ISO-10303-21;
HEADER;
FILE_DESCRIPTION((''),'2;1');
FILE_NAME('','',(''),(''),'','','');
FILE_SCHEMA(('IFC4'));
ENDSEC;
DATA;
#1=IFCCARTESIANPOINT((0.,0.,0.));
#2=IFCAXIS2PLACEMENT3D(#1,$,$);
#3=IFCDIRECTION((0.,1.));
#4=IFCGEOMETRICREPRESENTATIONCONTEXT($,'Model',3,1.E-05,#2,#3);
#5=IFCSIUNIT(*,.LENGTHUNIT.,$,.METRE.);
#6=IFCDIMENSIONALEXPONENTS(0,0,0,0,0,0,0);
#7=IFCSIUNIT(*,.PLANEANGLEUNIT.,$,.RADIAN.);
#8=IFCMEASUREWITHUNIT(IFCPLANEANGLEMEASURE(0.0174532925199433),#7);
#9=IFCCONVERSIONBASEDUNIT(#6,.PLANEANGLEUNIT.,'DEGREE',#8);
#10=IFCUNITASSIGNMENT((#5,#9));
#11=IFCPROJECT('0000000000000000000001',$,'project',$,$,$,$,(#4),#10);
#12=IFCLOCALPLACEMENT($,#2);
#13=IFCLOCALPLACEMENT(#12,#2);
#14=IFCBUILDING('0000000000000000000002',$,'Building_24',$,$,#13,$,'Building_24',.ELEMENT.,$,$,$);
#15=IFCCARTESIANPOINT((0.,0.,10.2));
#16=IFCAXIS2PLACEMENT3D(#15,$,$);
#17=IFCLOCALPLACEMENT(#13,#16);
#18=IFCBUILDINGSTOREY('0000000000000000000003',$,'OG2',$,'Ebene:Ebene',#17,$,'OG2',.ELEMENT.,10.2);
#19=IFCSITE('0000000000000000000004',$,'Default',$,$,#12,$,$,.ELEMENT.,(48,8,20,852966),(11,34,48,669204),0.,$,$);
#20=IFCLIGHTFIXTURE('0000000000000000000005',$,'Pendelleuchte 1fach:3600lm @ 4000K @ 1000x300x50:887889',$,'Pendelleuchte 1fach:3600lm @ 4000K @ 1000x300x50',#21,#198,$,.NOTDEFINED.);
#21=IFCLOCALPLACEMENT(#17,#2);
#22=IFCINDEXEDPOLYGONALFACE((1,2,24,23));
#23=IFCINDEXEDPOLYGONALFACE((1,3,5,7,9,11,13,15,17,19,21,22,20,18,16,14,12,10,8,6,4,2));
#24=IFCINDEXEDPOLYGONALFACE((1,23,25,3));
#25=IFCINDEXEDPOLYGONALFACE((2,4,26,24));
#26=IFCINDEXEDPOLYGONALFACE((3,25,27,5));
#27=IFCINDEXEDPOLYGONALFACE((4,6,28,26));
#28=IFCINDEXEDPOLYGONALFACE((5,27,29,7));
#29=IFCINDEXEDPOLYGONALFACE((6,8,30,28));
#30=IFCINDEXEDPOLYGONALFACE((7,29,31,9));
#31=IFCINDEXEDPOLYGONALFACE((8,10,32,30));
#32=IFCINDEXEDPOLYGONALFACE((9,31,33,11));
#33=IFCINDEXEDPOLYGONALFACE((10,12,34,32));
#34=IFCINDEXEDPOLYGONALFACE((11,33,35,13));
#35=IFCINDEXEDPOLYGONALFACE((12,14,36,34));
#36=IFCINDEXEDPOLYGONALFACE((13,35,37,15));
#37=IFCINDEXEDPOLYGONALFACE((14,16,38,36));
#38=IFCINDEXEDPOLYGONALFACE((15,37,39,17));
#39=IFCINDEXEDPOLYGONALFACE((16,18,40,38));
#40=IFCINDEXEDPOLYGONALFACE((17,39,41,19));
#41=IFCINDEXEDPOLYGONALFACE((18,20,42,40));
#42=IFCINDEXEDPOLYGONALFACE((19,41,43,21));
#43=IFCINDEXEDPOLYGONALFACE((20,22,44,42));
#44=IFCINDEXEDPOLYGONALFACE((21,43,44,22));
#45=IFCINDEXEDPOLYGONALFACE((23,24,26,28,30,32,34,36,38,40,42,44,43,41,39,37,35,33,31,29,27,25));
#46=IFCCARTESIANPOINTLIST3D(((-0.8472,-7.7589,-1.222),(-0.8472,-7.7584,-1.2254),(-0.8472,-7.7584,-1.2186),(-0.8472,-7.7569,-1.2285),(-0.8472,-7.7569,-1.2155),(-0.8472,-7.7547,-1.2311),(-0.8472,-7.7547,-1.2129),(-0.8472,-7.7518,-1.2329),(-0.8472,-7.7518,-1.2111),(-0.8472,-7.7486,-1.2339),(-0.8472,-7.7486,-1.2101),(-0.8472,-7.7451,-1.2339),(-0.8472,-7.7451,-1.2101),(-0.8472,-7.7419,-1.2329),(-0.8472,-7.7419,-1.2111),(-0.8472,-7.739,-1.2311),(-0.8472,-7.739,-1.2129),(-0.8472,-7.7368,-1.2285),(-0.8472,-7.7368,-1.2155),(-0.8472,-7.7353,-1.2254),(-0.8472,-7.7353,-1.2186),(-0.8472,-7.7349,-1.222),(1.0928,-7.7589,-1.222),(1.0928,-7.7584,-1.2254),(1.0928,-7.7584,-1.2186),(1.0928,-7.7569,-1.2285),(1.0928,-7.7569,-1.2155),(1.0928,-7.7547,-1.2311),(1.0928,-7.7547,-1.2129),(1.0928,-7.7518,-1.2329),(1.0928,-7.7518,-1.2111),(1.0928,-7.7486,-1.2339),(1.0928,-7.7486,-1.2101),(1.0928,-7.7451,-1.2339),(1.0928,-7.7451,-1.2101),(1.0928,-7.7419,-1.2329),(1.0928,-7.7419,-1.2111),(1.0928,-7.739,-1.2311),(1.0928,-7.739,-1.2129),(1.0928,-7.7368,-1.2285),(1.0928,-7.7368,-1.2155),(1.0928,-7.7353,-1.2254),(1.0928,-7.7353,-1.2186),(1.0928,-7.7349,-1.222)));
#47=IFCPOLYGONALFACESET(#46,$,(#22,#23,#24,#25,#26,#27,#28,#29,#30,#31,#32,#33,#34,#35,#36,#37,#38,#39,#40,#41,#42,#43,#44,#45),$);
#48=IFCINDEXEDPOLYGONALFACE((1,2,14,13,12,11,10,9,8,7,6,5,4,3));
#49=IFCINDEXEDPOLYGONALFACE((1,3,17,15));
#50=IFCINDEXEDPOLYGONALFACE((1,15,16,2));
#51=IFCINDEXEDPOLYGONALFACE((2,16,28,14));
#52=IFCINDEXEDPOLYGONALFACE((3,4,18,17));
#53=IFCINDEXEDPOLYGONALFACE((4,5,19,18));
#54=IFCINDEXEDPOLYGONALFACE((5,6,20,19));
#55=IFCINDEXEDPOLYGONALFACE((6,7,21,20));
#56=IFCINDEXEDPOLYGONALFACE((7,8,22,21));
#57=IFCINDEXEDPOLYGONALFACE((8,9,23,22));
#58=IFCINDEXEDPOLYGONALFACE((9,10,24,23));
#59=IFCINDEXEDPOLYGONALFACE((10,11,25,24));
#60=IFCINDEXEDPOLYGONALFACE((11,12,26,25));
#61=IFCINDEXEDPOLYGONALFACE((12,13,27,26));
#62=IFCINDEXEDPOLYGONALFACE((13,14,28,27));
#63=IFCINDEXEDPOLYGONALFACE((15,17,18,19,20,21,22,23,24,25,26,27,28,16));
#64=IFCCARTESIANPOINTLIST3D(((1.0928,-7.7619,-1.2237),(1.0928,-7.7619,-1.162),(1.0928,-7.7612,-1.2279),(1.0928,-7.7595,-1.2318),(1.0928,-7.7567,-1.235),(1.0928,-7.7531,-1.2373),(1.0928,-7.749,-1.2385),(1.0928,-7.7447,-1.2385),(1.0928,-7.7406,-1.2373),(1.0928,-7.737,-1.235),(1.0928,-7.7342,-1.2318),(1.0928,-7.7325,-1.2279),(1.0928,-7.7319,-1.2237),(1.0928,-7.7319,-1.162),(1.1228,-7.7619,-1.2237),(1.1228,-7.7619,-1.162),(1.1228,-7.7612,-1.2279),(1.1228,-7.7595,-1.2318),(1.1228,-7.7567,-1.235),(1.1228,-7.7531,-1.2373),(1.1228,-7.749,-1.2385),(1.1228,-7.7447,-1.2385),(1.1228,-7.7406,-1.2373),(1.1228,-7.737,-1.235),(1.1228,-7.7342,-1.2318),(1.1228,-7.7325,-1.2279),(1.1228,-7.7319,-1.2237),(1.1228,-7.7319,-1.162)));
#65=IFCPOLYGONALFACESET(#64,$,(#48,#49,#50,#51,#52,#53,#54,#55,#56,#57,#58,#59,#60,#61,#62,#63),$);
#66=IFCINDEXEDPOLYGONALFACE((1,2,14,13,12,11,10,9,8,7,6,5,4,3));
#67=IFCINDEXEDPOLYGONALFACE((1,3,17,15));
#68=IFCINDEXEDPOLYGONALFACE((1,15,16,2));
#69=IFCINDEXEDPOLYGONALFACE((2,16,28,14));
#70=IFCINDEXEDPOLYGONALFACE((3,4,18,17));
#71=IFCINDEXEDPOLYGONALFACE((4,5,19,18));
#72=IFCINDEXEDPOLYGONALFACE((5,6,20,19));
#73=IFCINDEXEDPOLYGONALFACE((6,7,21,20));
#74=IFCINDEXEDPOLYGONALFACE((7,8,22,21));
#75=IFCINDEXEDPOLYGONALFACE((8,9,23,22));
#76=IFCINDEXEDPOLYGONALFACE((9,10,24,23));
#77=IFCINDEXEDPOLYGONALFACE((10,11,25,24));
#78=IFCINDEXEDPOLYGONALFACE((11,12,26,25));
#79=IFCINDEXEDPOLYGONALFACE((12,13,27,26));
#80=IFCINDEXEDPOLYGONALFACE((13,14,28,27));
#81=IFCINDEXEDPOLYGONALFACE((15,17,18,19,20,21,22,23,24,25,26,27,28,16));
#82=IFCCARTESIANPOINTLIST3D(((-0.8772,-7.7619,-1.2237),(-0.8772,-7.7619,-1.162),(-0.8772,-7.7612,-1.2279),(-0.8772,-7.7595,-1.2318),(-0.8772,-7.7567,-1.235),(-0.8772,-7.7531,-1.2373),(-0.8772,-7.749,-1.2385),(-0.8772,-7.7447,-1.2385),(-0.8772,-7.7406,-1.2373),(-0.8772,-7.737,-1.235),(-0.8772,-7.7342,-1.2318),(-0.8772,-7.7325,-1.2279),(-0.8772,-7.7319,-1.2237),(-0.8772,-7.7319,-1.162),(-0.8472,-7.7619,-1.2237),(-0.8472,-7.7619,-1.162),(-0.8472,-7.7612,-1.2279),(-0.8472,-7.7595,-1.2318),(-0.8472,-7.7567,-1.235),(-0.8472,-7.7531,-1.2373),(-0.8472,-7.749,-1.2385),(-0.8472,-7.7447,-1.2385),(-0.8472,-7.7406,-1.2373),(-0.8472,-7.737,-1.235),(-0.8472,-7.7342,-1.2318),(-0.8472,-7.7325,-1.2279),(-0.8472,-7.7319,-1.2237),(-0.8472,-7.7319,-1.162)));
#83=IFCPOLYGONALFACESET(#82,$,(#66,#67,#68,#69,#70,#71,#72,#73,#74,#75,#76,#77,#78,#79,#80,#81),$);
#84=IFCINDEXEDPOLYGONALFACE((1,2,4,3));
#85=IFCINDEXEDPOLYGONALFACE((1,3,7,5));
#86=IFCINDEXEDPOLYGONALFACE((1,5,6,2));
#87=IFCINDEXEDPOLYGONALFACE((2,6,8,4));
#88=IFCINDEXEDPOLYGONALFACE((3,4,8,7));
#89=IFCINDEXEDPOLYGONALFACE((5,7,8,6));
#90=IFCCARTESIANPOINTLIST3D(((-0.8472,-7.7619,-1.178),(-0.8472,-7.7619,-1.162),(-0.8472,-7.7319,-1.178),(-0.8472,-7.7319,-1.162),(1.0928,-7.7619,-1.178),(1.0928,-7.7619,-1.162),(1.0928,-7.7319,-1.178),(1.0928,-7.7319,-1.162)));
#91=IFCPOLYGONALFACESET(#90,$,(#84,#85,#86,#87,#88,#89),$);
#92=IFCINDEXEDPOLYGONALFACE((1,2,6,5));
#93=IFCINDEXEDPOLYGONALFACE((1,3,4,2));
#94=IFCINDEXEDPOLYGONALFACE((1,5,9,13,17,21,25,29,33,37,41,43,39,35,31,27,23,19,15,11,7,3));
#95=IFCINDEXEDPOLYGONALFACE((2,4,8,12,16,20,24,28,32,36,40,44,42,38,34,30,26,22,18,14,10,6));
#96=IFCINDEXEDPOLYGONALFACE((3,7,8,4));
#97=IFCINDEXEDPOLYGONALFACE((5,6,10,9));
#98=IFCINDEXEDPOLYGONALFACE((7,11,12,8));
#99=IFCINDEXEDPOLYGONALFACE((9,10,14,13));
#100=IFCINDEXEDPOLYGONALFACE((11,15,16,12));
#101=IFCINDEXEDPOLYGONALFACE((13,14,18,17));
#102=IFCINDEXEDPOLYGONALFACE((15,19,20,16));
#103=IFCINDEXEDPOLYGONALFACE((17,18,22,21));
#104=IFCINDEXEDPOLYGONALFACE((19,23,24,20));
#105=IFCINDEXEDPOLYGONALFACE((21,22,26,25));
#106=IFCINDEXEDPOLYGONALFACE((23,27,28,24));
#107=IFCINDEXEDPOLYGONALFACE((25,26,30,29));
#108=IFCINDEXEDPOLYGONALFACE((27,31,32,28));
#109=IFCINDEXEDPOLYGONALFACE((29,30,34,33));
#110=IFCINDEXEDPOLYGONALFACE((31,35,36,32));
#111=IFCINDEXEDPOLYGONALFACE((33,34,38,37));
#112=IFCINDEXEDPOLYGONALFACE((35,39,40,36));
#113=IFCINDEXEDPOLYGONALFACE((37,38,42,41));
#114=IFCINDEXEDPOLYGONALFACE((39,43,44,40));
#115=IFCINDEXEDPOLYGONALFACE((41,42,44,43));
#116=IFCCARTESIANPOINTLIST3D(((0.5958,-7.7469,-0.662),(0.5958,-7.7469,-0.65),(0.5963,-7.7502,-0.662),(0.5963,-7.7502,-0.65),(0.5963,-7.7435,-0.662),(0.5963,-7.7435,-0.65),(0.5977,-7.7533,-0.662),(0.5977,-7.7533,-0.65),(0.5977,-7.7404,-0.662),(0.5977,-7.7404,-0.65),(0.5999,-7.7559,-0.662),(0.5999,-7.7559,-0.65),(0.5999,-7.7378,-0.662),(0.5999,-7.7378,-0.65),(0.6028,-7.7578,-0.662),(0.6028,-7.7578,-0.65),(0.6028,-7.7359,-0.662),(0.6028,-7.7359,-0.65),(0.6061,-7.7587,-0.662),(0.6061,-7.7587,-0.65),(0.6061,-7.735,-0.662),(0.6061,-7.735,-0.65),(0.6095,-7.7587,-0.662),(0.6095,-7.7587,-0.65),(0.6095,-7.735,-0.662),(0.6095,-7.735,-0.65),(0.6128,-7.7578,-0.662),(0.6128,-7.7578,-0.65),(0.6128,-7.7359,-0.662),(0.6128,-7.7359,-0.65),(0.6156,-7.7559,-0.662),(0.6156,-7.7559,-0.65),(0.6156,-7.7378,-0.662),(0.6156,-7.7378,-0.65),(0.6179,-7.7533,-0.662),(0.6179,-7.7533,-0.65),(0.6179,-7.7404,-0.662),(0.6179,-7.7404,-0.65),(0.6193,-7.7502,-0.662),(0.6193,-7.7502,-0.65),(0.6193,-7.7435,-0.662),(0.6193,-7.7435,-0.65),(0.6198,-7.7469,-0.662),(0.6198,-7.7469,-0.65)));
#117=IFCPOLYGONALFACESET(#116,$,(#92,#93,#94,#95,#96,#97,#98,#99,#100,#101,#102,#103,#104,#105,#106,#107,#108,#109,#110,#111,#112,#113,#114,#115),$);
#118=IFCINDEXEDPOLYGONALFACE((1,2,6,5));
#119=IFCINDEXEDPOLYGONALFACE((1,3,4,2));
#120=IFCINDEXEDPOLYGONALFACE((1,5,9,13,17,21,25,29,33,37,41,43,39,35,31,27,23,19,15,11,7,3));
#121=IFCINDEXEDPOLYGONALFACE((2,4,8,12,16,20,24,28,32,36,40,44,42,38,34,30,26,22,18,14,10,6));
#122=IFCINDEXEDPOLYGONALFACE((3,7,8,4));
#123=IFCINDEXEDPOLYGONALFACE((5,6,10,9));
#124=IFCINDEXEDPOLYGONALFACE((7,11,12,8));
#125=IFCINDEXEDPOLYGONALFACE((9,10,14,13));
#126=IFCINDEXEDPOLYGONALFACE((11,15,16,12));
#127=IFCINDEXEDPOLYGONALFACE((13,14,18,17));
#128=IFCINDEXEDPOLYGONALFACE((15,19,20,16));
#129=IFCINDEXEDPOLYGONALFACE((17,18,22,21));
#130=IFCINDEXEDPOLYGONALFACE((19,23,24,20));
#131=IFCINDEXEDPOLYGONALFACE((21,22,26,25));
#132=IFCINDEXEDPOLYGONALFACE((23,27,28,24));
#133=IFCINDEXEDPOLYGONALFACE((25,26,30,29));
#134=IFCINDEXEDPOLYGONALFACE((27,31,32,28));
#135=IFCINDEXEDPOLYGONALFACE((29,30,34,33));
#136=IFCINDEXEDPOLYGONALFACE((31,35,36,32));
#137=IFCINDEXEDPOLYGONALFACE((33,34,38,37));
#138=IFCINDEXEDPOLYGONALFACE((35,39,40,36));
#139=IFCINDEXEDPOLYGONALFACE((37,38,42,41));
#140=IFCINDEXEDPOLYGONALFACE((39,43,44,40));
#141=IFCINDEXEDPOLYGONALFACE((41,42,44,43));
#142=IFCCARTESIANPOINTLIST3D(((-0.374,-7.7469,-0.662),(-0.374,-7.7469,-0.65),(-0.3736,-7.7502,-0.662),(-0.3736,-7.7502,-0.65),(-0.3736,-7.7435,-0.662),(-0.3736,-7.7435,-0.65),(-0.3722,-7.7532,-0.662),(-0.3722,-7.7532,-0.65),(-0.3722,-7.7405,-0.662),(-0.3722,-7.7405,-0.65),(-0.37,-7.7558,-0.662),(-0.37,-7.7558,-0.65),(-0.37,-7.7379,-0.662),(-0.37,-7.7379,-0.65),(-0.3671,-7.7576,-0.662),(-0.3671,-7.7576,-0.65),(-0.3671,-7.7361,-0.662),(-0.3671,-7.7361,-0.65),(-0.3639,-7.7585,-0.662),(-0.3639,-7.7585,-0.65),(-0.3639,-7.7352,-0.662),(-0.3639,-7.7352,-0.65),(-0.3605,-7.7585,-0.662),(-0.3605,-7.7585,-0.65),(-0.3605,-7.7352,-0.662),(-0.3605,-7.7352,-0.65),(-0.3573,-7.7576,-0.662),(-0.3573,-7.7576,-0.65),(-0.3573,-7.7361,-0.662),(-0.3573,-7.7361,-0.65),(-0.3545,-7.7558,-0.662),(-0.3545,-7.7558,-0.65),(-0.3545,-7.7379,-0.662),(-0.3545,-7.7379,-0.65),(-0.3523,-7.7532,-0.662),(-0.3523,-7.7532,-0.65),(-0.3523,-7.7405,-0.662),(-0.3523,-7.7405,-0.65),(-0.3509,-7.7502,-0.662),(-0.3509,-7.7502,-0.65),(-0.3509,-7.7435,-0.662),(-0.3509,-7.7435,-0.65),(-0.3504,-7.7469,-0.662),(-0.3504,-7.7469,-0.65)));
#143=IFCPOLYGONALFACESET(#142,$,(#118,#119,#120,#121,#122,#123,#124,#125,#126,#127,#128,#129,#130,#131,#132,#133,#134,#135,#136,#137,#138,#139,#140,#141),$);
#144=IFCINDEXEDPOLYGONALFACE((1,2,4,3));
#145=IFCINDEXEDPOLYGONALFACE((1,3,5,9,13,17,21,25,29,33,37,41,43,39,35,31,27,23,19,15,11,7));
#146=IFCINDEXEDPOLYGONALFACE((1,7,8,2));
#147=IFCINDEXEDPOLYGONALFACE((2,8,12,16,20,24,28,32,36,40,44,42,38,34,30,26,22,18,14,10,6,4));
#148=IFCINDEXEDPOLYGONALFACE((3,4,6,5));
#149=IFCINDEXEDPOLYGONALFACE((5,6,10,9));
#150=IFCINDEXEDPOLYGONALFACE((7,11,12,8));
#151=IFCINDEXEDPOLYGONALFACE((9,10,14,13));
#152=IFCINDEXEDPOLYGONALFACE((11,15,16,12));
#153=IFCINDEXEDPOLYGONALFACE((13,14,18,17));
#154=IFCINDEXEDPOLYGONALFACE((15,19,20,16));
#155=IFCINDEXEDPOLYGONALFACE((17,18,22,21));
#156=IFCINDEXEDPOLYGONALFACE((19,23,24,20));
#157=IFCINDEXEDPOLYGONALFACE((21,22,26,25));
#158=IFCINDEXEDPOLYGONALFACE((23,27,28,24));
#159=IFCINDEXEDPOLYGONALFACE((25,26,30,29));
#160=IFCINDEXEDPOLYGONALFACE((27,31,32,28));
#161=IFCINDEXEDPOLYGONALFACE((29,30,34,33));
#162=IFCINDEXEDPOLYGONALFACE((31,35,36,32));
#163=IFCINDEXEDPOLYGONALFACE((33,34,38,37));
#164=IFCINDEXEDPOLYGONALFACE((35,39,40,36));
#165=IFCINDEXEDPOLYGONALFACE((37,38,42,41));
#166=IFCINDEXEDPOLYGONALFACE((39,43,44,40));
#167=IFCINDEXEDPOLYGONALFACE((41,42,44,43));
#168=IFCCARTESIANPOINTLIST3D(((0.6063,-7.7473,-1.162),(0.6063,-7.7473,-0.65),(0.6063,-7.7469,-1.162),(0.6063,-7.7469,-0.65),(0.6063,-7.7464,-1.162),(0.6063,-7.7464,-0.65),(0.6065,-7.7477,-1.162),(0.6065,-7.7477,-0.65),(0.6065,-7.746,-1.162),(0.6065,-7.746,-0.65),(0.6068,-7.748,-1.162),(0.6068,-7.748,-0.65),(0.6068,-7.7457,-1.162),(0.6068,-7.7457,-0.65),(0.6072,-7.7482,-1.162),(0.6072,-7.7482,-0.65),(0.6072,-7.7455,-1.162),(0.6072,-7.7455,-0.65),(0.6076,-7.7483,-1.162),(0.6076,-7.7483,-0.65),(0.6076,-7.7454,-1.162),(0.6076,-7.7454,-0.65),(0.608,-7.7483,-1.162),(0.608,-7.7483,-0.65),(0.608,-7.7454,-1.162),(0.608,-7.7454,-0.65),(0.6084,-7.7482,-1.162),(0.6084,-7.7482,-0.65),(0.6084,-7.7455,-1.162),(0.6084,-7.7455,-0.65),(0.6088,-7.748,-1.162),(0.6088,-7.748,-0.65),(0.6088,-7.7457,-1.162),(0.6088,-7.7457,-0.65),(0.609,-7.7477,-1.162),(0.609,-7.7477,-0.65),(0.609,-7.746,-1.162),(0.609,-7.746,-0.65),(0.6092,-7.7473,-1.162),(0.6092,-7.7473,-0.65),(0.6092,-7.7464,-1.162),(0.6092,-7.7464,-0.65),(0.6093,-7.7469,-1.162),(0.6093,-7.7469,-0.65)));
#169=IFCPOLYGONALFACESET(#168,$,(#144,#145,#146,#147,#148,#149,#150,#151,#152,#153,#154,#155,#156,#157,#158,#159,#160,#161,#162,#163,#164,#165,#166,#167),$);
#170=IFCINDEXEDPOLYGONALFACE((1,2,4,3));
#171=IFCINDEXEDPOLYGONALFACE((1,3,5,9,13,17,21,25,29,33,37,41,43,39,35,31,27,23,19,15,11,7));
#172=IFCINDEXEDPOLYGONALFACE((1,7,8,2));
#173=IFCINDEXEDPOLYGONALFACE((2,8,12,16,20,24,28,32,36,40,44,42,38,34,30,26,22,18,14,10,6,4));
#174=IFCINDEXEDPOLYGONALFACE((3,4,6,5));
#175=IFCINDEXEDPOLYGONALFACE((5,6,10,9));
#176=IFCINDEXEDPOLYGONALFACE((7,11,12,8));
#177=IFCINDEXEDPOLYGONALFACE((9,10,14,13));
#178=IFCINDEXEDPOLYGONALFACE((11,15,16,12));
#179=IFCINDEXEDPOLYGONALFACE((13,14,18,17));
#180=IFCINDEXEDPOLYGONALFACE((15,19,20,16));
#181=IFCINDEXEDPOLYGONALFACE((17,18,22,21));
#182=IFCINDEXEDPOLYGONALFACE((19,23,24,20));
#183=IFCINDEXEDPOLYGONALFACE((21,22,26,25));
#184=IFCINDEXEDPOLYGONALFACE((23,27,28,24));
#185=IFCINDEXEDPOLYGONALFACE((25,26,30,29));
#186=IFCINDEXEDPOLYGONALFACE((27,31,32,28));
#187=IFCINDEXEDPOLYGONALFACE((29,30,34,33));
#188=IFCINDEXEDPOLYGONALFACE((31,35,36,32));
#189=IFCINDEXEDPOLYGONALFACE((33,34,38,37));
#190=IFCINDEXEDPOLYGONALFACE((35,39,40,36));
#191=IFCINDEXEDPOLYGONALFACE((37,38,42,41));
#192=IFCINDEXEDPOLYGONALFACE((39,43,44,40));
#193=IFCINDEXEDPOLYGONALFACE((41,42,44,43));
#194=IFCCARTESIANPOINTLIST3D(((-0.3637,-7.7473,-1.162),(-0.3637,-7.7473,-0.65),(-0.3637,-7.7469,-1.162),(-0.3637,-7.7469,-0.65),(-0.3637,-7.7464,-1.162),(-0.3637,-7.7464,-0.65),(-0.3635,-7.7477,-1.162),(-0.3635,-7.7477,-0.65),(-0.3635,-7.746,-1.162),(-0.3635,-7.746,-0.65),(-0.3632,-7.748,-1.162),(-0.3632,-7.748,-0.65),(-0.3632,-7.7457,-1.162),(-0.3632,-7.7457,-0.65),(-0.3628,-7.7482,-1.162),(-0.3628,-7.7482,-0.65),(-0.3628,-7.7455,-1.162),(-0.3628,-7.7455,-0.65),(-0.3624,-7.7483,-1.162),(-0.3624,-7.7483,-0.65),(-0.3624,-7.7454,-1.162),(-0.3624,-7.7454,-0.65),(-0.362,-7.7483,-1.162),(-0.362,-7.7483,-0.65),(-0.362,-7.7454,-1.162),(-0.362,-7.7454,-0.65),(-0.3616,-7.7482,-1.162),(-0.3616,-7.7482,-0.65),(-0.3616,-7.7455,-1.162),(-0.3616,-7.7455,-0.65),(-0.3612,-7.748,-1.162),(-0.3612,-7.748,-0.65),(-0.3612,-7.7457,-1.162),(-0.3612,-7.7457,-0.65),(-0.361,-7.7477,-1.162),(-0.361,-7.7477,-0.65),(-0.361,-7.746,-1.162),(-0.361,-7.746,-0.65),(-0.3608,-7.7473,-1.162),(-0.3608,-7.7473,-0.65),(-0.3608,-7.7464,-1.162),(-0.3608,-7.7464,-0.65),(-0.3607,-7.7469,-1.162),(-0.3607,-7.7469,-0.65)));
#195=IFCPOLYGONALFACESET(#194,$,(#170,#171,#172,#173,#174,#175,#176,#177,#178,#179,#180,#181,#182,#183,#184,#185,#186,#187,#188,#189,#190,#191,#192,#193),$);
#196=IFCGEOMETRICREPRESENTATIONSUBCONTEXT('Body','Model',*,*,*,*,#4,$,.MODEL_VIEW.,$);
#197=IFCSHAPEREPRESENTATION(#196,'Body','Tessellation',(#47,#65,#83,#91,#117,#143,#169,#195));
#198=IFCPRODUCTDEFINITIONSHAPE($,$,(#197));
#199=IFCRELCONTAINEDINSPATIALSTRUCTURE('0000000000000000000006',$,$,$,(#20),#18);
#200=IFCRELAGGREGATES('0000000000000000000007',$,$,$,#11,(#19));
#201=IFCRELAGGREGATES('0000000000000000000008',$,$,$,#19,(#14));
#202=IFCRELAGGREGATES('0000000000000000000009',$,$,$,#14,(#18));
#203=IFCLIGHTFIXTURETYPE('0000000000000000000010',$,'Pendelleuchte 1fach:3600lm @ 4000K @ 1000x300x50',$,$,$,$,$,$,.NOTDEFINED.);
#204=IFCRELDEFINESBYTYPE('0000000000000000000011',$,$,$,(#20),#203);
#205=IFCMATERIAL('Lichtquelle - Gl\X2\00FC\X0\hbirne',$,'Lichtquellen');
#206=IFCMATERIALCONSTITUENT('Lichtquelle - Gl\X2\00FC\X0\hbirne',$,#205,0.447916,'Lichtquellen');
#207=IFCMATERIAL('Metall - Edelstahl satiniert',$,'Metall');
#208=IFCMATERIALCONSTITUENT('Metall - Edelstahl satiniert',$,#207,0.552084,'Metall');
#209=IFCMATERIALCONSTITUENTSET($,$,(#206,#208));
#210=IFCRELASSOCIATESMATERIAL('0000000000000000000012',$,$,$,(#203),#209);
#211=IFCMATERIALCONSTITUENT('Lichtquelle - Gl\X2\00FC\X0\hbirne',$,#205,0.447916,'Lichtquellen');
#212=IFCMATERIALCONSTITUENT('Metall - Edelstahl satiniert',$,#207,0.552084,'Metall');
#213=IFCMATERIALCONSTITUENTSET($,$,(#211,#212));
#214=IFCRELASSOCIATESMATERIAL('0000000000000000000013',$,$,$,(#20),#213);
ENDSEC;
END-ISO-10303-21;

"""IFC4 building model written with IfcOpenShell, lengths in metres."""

from ifc_helpers import new_model, entity, si_unit, converted_unit, direction, frame, origin, place, context, subcontext, project, spatial, line, arc, indexed_curve, outline, extrude, source, transform, mapped, material, constituent, constituent_set, type_object, type_shapes, element, save


model = new_model("IFC4")

# Units and contexts
model_context = context("Model", 3, precision=1e-05, world=origin(), true_north=direction((0.0, 1.0)))
body_context = subcontext(model_context, "Body", "Model", "MODEL_VIEW")
ifc_project = project(units=[si_unit("LENGTHUNIT", "METRE"), converted_unit("PLANEANGLEUNIT", "DEGREE", entity("IfcPlaneAngleMeasure", 0.0174532925199433), si_unit("PLANEANGLEUNIT", "RADIAN"), dimensions=[0, 0, 0, 0, 0, 0, 0])], contexts=[model_context])

# Site, building, storey
site_placement = place(None, origin())
site = spatial("IfcSite", under=ifc_project, at=site_placement, Name="Default", CompositionType="ELEMENT", RefLatitude=(48, 8, 20, 852966), RefLongitude=(11, 34, 48, 669204), RefElevation=0.0)
building_placement = place(site_placement, origin())
building = spatial("IfcBuilding", under=site, at=building_placement, Name="Building_24", LongName="Building_24", CompositionType="ELEMENT")
storey_placement = place(building_placement, frame((0.0, 0.0, 10.2)))
storey = spatial("IfcBuildingStorey", under=building, at=storey_placement, Name="OG2", ObjectType="Ebene:Ebene", LongName="OG2", CompositionType="ELEMENT", Elevation=10.2)

# Light fixture
ifc_material_1 = material(Name="Lichtquelle - Glühbirne", Category="Lichtquellen")
ifc_material_2 = material(Name="Metall - Edelstahl satiniert", Category="Metall")
ifc_constituent_1 = constituent(ifc_material_1, Name="Lichtquelle - Glühbirne", Category="Lichtquellen", fraction=0.447916)
ifc_constituent_2 = constituent(ifc_material_2, Name="Metall - Edelstahl satiniert", Category="Metall", fraction=0.552084)
ifc_constituent_set_1 = constituent_set(constituents=[ifc_constituent_1, ifc_constituent_2])
light_fixture_type_1 = type_object("IfcLightFixtureType", Name="Pendelleuchte 1fach:3600lm @ 4000K @ 1000x300x50", PredefinedType="NOTDEFINED", material=ifc_constituent_set_1)
shared_shape_1 = source(origin(), body_context, "Body", "SweptSolid", [
    extrude(outline(indexed_curve([(-0.012, 0.0), (0.0, -0.012), (0.012, 0.0), (0.0, 0.012)], segments=[arc(1, 2, 3), arc(3, 4, 1)], self_intersect=False)), frame((-0.97, 0.0, -0.572), z_axis=(1.0, 0.0, 0.0), x_axis=(0.0, 1.0, 0.0)), (0.0, 0.0, 1.0), 1.94),
    extrude(outline(indexed_curve([(-0.0308, -0.015), (0.0308, -0.015), (0.0308, 0.015), (-0.0308, 0.015), (-0.0458, 0.0)], segments=[line(1, 2, 3, 4), arc(4, 5, 1)], self_intersect=False)), frame((0.97, 0.0, -0.5428), z_axis=(1.0, 0.0, 0.0), x_axis=(0.0, 0.0, 1.0)), (0.0, 0.0, 1.0), 0.03),
    extrude(outline(indexed_curve([(-0.0308, -0.015), (0.0308, -0.015), (0.0308, 0.015), (-0.0308, 0.015), (-0.0458, 0.0)], segments=[line(1, 2, 3, 4), arc(4, 5, 1)], self_intersect=False)), frame((-1.0, 0.0, -0.5428), z_axis=(1.0, 0.0, 0.0), x_axis=(0.0, 0.0, 1.0)), (0.0, 0.0, 1.0), 0.03),
    extrude(outline(indexed_curve([(-0.97, -0.015), (0.97, -0.015), (0.97, 0.015), (-0.97, 0.015), (-0.97, -0.015)], self_intersect=False)), frame((0.0, 0.0, -0.528), z_axis=(0.0, 0.0, 1.0), x_axis=(-1.0, 0.0, 0.0)), (0.0, 0.0, 1.0), 0.016),
    extrude(outline(indexed_curve([(-0.012, 0.0), (0.0, -0.012), (0.012, 0.0), (0.0, 0.012)], segments=[arc(1, 2, 3), arc(3, 4, 1)], self_intersect=False)), frame((0.485, 0.0, -0.012)), (0.0, 0.0, 1.0), 0.012),
    extrude(outline(indexed_curve([(-0.0118, 0.0), (0.0, -0.0118), (0.0118, 0.0), (0.0, 0.0118)], segments=[arc(1, 2, 3), arc(3, 4, 1)], self_intersect=False)), frame((-0.485, 0.0, -0.012)), (0.0, 0.0, 1.0), 0.012),
    extrude(outline(indexed_curve([(-0.0015, 0.0), (0.0, -0.0015), (0.0015, 0.0), (0.0, 0.0015)], segments=[arc(1, 2, 3), arc(3, 4, 1)], self_intersect=False)), frame((0.485, 0.0, -0.512)), (0.0, 0.0, 1.0), 0.512),
    extrude(outline(indexed_curve([(-0.0015, 0.0), (0.0, -0.0015), (0.0015, 0.0), (0.0, 0.0015)], segments=[arc(1, 2, 3), arc(3, 4, 1)], self_intersect=False)), frame((-0.485, 0.0, -0.512)), (0.0, 0.0, 1.0), 0.512),
])
type_shapes(light_fixture_type_1, [shared_shape_1])
ifc_constituent_3 = constituent(ifc_material_1, Name="Lichtquelle - Glühbirne", Category="Lichtquellen", fraction=0.447916)
ifc_constituent_4 = constituent(ifc_material_2, Name="Metall - Edelstahl satiniert", Category="Metall", fraction=0.552084)
ifc_constituent_set_2 = constituent_set(constituents=[ifc_constituent_3, ifc_constituent_4])
light_fixture_1_placement = place(storey_placement, frame((0.1228, -7.7469, -0.65)))
element("IfcLightFixture", 1, at=light_fixture_1_placement, inside=storey, type_object=light_fixture_type_1, material=ifc_constituent_set_2, Name="Pendelleuchte 1fach:3600lm @ 4000K @ 1000x300x50:887889", ObjectType="Pendelleuchte 1fach:3600lm @ 4000K @ 1000x300x50", PredefinedType="NOTDEFINED", context=body_context, shape_type="MappedRepresentation", body=[
    mapped(shared_shape_1, transform((0.0, 0.0, 0.0), scale=1.0)),
])

save(model, "model.ifc")
